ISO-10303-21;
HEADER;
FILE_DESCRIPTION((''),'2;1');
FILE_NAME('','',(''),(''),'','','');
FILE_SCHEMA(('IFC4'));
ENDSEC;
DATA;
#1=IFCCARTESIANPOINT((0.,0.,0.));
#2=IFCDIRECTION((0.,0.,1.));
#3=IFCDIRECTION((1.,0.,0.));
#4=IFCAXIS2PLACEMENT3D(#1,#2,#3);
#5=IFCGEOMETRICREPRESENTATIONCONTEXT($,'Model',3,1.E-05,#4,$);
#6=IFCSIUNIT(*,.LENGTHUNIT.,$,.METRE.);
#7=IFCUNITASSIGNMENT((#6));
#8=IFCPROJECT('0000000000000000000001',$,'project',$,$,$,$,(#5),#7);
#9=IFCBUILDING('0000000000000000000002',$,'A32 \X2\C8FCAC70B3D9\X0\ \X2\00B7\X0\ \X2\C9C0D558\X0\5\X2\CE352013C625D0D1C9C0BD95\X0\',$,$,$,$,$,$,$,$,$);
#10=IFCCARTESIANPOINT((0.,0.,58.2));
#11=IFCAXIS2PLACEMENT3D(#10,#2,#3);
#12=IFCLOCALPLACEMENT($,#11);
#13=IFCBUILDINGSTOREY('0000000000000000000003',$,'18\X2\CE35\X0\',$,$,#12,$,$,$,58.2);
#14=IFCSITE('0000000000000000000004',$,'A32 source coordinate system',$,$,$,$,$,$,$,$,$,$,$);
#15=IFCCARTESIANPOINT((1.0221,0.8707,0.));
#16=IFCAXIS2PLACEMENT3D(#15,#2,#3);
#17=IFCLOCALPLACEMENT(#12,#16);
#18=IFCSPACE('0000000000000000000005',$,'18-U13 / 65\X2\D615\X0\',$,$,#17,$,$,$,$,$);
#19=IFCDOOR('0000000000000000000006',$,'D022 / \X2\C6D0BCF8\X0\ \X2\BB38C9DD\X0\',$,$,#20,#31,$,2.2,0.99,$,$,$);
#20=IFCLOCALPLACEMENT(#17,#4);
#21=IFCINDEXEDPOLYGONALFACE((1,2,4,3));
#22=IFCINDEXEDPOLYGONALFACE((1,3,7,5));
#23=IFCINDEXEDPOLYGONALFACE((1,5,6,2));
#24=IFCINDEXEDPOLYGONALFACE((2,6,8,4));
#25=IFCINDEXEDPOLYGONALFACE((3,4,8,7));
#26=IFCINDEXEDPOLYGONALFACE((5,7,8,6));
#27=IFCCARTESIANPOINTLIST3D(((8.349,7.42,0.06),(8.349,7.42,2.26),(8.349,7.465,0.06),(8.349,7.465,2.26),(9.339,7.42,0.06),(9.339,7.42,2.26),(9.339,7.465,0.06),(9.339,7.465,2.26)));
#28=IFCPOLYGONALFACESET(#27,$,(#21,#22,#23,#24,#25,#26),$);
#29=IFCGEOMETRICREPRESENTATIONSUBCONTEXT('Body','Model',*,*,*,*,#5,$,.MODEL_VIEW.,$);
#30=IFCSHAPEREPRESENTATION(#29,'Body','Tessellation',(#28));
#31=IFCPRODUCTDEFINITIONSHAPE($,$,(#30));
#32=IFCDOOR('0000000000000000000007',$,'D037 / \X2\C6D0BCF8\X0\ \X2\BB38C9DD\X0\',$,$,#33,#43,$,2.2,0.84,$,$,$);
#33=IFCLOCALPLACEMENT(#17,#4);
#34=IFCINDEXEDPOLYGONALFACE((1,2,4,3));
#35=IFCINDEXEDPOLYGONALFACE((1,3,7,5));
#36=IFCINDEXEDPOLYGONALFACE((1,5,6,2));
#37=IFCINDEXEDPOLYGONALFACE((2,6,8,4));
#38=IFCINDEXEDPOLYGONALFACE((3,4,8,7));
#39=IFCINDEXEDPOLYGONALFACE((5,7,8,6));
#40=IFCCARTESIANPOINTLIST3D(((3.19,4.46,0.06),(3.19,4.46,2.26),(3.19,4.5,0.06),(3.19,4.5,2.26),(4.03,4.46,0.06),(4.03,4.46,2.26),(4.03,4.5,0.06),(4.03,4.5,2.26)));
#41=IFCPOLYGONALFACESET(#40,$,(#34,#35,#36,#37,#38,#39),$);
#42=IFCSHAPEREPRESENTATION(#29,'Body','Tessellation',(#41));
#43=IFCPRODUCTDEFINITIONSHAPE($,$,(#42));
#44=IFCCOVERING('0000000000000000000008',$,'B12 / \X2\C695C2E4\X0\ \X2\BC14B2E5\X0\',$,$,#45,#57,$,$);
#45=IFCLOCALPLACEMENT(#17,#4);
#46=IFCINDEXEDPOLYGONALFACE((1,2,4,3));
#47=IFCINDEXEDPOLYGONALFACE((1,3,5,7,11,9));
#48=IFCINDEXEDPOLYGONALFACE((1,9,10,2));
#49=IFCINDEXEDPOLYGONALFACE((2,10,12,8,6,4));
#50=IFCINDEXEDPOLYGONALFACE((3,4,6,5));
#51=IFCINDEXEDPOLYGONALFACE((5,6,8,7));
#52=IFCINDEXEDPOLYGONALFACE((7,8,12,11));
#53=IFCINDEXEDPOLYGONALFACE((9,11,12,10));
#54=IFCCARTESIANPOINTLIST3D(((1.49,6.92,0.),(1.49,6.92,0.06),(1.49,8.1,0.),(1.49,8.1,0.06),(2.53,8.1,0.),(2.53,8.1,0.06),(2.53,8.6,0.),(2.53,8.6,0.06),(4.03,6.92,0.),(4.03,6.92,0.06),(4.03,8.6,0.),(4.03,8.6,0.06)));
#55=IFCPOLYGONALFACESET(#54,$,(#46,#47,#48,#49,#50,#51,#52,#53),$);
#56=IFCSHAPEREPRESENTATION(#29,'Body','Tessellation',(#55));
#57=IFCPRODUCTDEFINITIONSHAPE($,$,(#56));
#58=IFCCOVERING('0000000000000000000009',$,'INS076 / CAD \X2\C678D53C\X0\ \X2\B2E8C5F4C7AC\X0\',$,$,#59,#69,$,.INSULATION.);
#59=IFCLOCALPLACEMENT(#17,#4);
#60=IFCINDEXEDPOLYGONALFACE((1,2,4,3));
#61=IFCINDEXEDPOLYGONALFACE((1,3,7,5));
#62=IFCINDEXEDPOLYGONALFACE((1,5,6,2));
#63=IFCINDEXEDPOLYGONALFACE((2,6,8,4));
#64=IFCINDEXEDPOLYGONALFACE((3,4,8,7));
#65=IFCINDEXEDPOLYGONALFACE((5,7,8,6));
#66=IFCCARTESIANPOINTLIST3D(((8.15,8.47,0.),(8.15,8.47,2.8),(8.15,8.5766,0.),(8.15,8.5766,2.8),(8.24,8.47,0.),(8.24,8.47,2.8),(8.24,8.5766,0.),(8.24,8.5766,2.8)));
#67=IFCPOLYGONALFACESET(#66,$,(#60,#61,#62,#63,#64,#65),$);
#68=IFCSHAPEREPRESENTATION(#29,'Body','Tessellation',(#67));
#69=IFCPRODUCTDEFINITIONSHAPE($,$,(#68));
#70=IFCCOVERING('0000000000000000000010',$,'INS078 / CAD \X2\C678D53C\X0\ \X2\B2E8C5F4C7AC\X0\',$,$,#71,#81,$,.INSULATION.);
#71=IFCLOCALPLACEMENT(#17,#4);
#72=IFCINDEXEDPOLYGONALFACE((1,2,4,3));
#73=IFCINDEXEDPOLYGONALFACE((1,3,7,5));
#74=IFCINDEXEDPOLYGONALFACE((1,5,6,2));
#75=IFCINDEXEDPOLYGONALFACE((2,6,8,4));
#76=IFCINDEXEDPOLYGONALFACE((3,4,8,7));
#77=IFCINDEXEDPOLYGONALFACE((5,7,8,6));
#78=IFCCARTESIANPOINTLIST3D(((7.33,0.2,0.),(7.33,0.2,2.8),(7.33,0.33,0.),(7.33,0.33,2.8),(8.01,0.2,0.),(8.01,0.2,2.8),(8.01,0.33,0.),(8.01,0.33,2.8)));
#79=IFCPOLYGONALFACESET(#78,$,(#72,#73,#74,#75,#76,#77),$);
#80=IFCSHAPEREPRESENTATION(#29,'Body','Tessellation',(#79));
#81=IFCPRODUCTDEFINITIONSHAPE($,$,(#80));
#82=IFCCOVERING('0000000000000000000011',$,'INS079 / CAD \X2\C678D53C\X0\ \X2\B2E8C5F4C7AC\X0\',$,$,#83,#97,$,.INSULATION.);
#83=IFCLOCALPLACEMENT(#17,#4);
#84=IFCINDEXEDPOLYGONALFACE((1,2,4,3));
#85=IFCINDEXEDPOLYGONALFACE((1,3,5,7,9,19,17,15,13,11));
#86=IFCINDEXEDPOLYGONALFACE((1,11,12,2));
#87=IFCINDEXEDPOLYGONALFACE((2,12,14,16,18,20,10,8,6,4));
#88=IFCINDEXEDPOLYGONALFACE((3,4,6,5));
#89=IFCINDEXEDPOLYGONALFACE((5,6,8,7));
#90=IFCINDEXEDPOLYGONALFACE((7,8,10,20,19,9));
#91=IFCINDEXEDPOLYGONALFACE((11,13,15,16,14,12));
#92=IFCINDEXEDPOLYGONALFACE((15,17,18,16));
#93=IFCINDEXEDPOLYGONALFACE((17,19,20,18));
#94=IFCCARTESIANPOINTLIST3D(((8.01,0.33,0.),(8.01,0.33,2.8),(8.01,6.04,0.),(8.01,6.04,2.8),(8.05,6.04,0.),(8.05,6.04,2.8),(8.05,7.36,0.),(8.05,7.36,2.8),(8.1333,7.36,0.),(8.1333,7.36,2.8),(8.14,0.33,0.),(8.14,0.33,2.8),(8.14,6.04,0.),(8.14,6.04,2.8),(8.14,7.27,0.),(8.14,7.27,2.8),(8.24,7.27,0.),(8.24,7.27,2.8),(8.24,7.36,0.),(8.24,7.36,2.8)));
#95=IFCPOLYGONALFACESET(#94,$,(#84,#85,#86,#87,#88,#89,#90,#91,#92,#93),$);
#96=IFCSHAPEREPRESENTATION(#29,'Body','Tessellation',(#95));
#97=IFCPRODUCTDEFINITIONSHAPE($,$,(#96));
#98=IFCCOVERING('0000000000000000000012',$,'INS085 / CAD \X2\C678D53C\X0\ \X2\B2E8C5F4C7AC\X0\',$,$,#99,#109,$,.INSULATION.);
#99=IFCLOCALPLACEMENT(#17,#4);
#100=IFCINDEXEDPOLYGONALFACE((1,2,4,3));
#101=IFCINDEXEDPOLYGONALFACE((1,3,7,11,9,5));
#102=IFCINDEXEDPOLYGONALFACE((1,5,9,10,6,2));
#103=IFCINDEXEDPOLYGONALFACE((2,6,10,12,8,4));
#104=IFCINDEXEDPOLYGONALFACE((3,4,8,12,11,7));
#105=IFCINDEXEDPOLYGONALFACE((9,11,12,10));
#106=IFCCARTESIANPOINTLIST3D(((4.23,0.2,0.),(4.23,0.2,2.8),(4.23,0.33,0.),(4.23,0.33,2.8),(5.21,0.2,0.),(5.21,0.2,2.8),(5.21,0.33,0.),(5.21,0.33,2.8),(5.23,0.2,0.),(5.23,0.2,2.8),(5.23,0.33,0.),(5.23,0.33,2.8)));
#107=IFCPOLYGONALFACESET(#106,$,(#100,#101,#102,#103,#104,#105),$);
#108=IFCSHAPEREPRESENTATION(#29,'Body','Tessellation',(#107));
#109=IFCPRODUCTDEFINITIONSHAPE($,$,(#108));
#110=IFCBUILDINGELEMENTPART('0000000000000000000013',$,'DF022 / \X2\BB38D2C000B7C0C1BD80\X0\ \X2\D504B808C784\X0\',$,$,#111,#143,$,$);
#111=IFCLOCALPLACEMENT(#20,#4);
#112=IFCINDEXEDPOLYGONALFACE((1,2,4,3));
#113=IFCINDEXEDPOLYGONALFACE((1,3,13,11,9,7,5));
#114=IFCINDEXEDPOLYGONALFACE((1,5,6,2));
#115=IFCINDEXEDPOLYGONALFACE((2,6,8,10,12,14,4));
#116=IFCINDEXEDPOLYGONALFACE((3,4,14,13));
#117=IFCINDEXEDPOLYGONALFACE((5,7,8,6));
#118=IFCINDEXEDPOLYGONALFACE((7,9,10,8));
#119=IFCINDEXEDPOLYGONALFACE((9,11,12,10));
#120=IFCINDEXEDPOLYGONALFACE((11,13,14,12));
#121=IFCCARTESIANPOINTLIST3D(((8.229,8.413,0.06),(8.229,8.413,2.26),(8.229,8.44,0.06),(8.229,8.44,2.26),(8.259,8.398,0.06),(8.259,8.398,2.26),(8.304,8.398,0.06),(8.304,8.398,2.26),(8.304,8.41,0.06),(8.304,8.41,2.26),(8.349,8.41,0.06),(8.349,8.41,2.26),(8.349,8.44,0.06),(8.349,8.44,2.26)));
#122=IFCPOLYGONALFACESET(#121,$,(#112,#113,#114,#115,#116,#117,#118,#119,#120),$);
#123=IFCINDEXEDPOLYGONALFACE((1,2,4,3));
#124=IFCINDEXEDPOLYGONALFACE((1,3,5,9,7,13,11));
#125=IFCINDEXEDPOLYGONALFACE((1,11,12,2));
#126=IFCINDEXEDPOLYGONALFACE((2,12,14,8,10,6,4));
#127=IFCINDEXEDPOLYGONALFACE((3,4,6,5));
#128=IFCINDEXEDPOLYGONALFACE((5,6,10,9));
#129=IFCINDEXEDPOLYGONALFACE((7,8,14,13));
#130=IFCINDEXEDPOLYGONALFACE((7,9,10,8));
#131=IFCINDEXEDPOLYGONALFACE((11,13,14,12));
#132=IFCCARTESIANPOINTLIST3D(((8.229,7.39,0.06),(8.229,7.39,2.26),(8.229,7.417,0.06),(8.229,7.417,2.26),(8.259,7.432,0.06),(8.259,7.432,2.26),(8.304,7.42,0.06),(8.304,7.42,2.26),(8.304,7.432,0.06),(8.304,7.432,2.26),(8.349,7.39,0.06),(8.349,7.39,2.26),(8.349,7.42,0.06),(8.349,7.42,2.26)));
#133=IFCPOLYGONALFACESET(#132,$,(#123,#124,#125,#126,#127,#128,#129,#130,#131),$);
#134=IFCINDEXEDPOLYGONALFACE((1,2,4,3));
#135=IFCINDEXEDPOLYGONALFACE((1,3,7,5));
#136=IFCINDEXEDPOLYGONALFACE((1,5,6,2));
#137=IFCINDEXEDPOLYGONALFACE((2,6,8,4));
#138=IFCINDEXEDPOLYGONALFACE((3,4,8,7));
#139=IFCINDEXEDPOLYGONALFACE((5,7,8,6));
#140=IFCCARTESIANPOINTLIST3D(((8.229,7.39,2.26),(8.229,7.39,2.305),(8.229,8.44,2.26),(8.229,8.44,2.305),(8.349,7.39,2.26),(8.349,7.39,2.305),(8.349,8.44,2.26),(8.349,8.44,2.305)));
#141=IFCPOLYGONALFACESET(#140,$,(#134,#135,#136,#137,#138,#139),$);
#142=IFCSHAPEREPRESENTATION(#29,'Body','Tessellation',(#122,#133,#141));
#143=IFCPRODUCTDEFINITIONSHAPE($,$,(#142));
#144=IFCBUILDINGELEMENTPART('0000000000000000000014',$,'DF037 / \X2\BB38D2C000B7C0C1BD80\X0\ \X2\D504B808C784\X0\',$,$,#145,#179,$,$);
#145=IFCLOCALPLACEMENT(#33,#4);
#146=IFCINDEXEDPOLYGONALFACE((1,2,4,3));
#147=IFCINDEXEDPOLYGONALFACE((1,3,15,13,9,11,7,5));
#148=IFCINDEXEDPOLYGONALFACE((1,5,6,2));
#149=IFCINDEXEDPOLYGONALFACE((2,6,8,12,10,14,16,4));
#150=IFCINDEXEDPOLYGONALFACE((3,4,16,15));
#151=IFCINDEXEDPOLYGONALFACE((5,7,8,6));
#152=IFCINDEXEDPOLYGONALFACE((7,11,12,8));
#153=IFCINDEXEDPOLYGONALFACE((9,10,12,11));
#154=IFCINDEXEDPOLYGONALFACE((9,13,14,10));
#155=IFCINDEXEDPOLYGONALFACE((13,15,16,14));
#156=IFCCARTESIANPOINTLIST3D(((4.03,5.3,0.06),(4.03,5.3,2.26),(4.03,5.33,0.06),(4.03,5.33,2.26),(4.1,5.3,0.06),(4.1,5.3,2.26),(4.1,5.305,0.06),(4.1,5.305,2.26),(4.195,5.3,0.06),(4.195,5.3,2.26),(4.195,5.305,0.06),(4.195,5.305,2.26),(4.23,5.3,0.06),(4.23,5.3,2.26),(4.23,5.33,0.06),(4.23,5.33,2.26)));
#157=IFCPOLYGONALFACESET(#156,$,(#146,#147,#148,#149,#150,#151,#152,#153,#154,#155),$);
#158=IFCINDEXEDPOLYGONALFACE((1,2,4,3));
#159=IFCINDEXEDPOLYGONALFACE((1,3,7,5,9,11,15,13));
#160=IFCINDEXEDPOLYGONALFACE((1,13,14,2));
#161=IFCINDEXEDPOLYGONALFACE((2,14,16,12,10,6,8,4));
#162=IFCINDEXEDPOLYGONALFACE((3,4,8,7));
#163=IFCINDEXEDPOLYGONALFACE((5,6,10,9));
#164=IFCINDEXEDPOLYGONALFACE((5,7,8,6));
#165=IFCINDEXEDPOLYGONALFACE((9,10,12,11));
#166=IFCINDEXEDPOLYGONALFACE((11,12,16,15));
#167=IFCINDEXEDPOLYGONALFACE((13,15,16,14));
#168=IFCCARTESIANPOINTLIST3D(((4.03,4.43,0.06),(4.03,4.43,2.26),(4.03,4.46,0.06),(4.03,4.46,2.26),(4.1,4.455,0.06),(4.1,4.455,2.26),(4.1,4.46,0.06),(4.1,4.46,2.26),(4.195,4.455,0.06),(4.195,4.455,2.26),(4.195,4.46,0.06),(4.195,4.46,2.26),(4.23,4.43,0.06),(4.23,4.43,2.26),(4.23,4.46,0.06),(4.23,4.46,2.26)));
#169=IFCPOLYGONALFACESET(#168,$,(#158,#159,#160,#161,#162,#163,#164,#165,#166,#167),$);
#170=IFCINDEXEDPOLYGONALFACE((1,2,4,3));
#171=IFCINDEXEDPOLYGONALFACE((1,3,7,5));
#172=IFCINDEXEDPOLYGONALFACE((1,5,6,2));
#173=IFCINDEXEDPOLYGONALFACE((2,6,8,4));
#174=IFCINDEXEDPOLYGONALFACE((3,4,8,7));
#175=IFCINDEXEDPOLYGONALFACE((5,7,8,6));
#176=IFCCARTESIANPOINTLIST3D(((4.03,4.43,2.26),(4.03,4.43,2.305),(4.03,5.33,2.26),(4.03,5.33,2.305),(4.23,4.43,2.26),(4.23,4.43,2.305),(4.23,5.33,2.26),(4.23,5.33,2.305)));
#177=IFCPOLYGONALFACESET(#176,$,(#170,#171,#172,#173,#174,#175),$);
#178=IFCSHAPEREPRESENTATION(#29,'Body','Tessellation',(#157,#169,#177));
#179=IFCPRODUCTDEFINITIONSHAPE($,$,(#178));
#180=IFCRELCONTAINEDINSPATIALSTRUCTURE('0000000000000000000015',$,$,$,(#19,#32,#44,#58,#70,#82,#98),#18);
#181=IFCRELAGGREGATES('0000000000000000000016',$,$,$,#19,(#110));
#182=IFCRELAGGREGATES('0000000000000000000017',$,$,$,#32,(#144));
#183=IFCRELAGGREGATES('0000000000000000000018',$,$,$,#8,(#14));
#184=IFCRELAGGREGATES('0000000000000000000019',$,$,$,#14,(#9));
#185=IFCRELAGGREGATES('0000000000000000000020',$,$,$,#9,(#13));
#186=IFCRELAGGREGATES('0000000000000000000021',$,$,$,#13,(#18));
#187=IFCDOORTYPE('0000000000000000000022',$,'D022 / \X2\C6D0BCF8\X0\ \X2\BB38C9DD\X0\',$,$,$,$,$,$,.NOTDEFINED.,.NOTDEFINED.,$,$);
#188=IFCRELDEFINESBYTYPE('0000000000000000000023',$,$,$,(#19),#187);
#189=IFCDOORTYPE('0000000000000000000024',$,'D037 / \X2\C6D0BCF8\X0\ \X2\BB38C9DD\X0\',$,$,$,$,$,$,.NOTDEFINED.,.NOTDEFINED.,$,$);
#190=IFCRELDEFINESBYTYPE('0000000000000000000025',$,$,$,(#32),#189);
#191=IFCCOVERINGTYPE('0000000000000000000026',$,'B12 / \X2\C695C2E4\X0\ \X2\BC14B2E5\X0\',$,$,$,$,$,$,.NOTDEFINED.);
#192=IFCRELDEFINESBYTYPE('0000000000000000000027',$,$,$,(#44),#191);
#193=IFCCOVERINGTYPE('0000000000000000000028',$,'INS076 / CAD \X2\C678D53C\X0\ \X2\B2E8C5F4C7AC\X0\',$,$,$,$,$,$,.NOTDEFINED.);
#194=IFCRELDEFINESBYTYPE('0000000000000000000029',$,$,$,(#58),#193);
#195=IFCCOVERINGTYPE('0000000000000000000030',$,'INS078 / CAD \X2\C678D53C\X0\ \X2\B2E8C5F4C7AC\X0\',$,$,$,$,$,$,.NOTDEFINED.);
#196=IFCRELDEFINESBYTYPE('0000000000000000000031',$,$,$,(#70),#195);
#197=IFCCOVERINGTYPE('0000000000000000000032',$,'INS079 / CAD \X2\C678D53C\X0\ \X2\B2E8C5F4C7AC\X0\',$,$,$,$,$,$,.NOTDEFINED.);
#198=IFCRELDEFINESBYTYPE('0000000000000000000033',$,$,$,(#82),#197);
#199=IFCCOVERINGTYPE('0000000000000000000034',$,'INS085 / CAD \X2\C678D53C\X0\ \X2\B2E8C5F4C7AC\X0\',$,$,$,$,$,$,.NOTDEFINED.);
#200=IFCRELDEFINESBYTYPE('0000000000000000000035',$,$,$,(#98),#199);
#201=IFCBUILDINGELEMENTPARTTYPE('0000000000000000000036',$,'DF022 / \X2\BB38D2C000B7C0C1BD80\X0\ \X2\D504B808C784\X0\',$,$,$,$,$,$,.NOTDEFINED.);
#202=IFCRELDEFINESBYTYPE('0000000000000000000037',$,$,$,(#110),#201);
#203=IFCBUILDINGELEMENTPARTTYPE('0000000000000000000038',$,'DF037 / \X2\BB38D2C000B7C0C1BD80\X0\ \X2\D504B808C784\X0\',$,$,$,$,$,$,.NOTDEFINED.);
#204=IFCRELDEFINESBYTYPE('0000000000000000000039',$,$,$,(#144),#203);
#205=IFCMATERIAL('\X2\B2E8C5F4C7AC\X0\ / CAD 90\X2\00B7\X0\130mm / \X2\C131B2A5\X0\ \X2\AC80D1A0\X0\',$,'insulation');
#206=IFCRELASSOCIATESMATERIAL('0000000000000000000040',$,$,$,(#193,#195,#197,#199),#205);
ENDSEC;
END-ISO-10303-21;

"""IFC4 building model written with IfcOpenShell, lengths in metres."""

from ifc_helpers import new_model, si_unit, frame, origin, origin_with_axes, place, context, subcontext, project, spatial, polyline, outline, extrude, source, transform, mapped, material, type_object, type_shapes, element, aggregate, save


model = new_model("IFC4")

# Units and contexts
model_context = context("Model", 3, precision=1e-05, world=origin_with_axes())
body_context = subcontext(model_context, "Body", "Model", "MODEL_VIEW")
ifc_project = project(units=[si_unit("LENGTHUNIT", "METRE")], contexts=[model_context])

# Site, building, storey
site = spatial("IfcSite", under=ifc_project, Name="A32 source coordinate system")
building = spatial("IfcBuilding", under=site, Name="A32 주거동 · 지하5층–옥탑지붕")
storey_placement = place(None, frame((0.0, 0.0, 58.2), z_axis=(0.0, 0.0, 1.0), x_axis=(1.0, 0.0, 0.0)))
storey = spatial("IfcBuildingStorey", under=building, at=storey_placement, Name="18층", Elevation=58.2)

# Shared definitions
space_placement = place(storey_placement, frame((1.0221, 0.8707, 0.0), z_axis=(0.0, 0.0, 1.0), x_axis=(1.0, 0.0, 0.0)))
space = spatial("IfcSpace", under=storey, at=space_placement, Name="18-U13 / 65형")

# Doors
door_type_1 = type_object("IfcDoorType", Name="D022 / 원본 문짝", OperationType="NOTDEFINED", PredefinedType="NOTDEFINED")
shared_shape_1 = source(origin(), body_context, "Body", "SweptSolid", [
    extrude(outline(polyline([(9.339, 7.465), (9.339, 7.42), (8.349, 7.42), (8.349, 7.465), (9.339, 7.465)])), frame((0.0, 0.0, 0.06)), (0.0, 0.0, 1.0), 2.2),
])
type_shapes(door_type_1, [shared_shape_1])
door_1_placement = place(space_placement, origin_with_axes())
door_1 = element("IfcDoor", 1, at=door_1_placement, inside=space, type_object=door_type_1, Name="D022 / 원본 문짝", OverallHeight=2.2, OverallWidth=0.99, context=body_context, shape_type="MappedRepresentation", body=[
    mapped(shared_shape_1, transform((0.0, 0.0, 0.0), scale=1.0)),
])
door_type_2 = type_object("IfcDoorType", Name="D037 / 원본 문짝", OperationType="NOTDEFINED", PredefinedType="NOTDEFINED")
shared_shape_2 = source(origin(), body_context, "Body", "SweptSolid", [
    extrude(outline(polyline([(4.03, 4.46), (3.19, 4.46), (3.19, 4.5), (4.03, 4.5), (4.03, 4.46)])), frame((0.0, 0.0, 0.06)), (0.0, 0.0, 1.0), 2.2),
])
type_shapes(door_type_2, [shared_shape_2])
door_2_placement = place(space_placement, origin_with_axes())
door_2 = element("IfcDoor", 2, at=door_2_placement, inside=space, type_object=door_type_2, Name="D037 / 원본 문짝", OverallHeight=2.2, OverallWidth=0.84, context=body_context, shape_type="MappedRepresentation", body=[
    mapped(shared_shape_2, transform((0.0, 0.0, 0.0), scale=1.0)),
])

# Coverings
covering_type_1 = type_object("IfcCoveringType", Name="B12 / 욕실 바닥", PredefinedType="NOTDEFINED")
shared_shape_3 = source(origin(), body_context, "Body", "SweptSolid", [
    extrude(outline(polyline([(2.53, 8.6), (4.03, 8.6), (4.03, 6.92), (1.49, 6.92), (1.49, 8.1), (2.53, 8.1), (2.53, 8.6)])), origin(), (0.0, 0.0, 1.0), 0.06),
])
type_shapes(covering_type_1, [shared_shape_3])
covering_1_placement = place(space_placement, origin_with_axes())
element("IfcCovering", 3, at=covering_1_placement, inside=space, type_object=covering_type_1, Name="B12 / 욕실 바닥", context=body_context, shape_type="MappedRepresentation", body=[
    mapped(shared_shape_3, transform((0.0, 0.0, 0.0), scale=1.0)),
])
ifc_material = material(Name="단열재 / CAD 90·130mm / 성능 검토", Category="insulation")
covering_type_2 = type_object("IfcCoveringType", Name="INS076 / CAD 외피 단열재", PredefinedType="NOTDEFINED", material=ifc_material)
shared_shape_4 = source(origin(), body_context, "Body", "SweptSolid", [
    extrude(outline(polyline([(8.24, 8.5766), (8.24, 8.47), (8.15, 8.47), (8.15, 8.5766), (8.24, 8.5766)])), origin(), (0.0, 0.0, 1.0), 2.8),
])
type_shapes(covering_type_2, [shared_shape_4])
covering_2_placement = place(space_placement, origin_with_axes())
element("IfcCovering", 4, at=covering_2_placement, inside=space, type_object=covering_type_2, Name="INS076 / CAD 외피 단열재", PredefinedType="INSULATION", context=body_context, shape_type="MappedRepresentation", body=[
    mapped(shared_shape_4, transform((0.0, 0.0, 0.0), scale=1.0)),
])
covering_type_3 = type_object("IfcCoveringType", Name="INS078 / CAD 외피 단열재", PredefinedType="NOTDEFINED", material=ifc_material)
shared_shape_5 = source(origin(), body_context, "Body", "SweptSolid", [
    extrude(outline(polyline([(8.01, 0.2), (7.33, 0.2), (7.33, 0.33), (8.01, 0.33), (8.01, 0.2)])), origin(), (0.0, 0.0, 1.0), 2.8),
])
type_shapes(covering_type_3, [shared_shape_5])
covering_3_placement = place(space_placement, origin_with_axes())
element("IfcCovering", 5, at=covering_3_placement, inside=space, type_object=covering_type_3, Name="INS078 / CAD 외피 단열재", PredefinedType="INSULATION", context=body_context, shape_type="MappedRepresentation", body=[
    mapped(shared_shape_5, transform((0.0, 0.0, 0.0), scale=1.0)),
])
covering_type_4 = type_object("IfcCoveringType", Name="INS079 / CAD 외피 단열재", PredefinedType="NOTDEFINED", material=ifc_material)
shared_shape_6 = source(origin(), body_context, "Body", "SweptSolid", [
    extrude(outline(polyline([(8.24, 7.27), (8.14, 7.27), (8.14, 6.04), (8.14, 0.33), (8.01, 0.33), (8.01, 6.04), (8.05, 6.04), (8.05, 7.36), (8.1333, 7.36), (8.24, 7.36), (8.24, 7.27)])), origin(), (0.0, 0.0, 1.0), 2.8),
])
type_shapes(covering_type_4, [shared_shape_6])
covering_4_placement = place(space_placement, origin_with_axes())
element("IfcCovering", 6, at=covering_4_placement, inside=space, type_object=covering_type_4, Name="INS079 / CAD 외피 단열재", PredefinedType="INSULATION", context=body_context, shape_type="MappedRepresentation", body=[
    mapped(shared_shape_6, transform((0.0, 0.0, 0.0), scale=1.0)),
])
covering_type_5 = type_object("IfcCoveringType", Name="INS085 / CAD 외피 단열재", PredefinedType="NOTDEFINED", material=ifc_material)
shared_shape_7 = source(origin(), body_context, "Body", "SweptSolid", [
    extrude(outline(polyline([(4.23, 0.2), (4.23, 0.33), (5.21, 0.33), (5.23, 0.33), (5.23, 0.2), (5.21, 0.2), (4.23, 0.2)])), origin(), (0.0, 0.0, 1.0), 2.8),
])
type_shapes(covering_type_5, [shared_shape_7])
covering_5_placement = place(space_placement, origin_with_axes())
element("IfcCovering", 7, at=covering_5_placement, inside=space, type_object=covering_type_5, Name="INS085 / CAD 외피 단열재", PredefinedType="INSULATION", context=body_context, shape_type="MappedRepresentation", body=[
    mapped(shared_shape_7, transform((0.0, 0.0, 0.0), scale=1.0)),
])

# Building element parts
building_element_part_type_1 = type_object("IfcBuildingElementPartType", Name="DF022 / 문틀·상부 프레임", PredefinedType="NOTDEFINED")
shared_shape_8 = source(origin(), body_context, "Body", "SweptSolid", [
    extrude(outline(polyline([(8.349, 8.41), (8.304, 8.41), (8.304, 8.398), (8.259, 8.398), (8.229, 8.413), (8.229, 8.44), (8.349, 8.44), (8.349, 8.41)])), frame((0.0, 0.0, 0.06)), (0.0, 0.0, 1.0), 2.2),
    extrude(outline(polyline([(8.229, 7.39), (8.229, 7.417), (8.259, 7.432), (8.304, 7.432), (8.304, 7.42), (8.349, 7.42), (8.349, 7.39), (8.229, 7.39)])), frame((0.0, 0.0, 0.06)), (0.0, 0.0, 1.0), 2.2),
    extrude(outline(polyline([(8.229, 7.39), (8.229, 8.44), (8.349, 8.44), (8.349, 7.39), (8.229, 7.39)])), frame((0.0, 0.0, 2.26)), (0.0, 0.0, 1.0), 0.045),
])
type_shapes(building_element_part_type_1, [shared_shape_8])
building_element_part_1_placement = place(door_1_placement, origin_with_axes())
building_element_part_1 = element("IfcBuildingElementPart", 8, at=building_element_part_1_placement, type_object=building_element_part_type_1, Name="DF022 / 문틀·상부 프레임", context=body_context, shape_type="MappedRepresentation", body=[
    mapped(shared_shape_8, transform((0.0, 0.0, 0.0), scale=1.0)),
])
aggregate(door_1, [building_element_part_1])
building_element_part_type_2 = type_object("IfcBuildingElementPartType", Name="DF037 / 문틀·상부 프레임", PredefinedType="NOTDEFINED")
shared_shape_9 = source(origin(), body_context, "Body", "SweptSolid", [
    extrude(outline(polyline([(4.23, 5.33), (4.23, 5.3), (4.195, 5.3), (4.195, 5.305), (4.1, 5.305), (4.1, 5.3), (4.03, 5.3), (4.03, 5.33), (4.23, 5.33)])), frame((0.0, 0.0, 0.06)), (0.0, 0.0, 1.0), 2.2),
    extrude(outline(polyline([(4.03, 4.46), (4.1, 4.46), (4.1, 4.455), (4.195, 4.455), (4.195, 4.46), (4.23, 4.46), (4.23, 4.43), (4.03, 4.43), (4.03, 4.46)])), frame((0.0, 0.0, 0.06)), (0.0, 0.0, 1.0), 2.2),
    extrude(outline(polyline([(4.03, 4.43), (4.03, 5.33), (4.23, 5.33), (4.23, 4.43), (4.03, 4.43)])), frame((0.0, 0.0, 2.26)), (0.0, 0.0, 1.0), 0.045),
])
type_shapes(building_element_part_type_2, [shared_shape_9])
building_element_part_2_placement = place(door_2_placement, origin_with_axes())
building_element_part_2 = element("IfcBuildingElementPart", 9, at=building_element_part_2_placement, type_object=building_element_part_type_2, Name="DF037 / 문틀·상부 프레임", context=body_context, shape_type="MappedRepresentation", body=[
    mapped(shared_shape_9, transform((0.0, 0.0, 0.0), scale=1.0)),
])
aggregate(door_2, [building_element_part_2])

save(model, "model.ifc")
